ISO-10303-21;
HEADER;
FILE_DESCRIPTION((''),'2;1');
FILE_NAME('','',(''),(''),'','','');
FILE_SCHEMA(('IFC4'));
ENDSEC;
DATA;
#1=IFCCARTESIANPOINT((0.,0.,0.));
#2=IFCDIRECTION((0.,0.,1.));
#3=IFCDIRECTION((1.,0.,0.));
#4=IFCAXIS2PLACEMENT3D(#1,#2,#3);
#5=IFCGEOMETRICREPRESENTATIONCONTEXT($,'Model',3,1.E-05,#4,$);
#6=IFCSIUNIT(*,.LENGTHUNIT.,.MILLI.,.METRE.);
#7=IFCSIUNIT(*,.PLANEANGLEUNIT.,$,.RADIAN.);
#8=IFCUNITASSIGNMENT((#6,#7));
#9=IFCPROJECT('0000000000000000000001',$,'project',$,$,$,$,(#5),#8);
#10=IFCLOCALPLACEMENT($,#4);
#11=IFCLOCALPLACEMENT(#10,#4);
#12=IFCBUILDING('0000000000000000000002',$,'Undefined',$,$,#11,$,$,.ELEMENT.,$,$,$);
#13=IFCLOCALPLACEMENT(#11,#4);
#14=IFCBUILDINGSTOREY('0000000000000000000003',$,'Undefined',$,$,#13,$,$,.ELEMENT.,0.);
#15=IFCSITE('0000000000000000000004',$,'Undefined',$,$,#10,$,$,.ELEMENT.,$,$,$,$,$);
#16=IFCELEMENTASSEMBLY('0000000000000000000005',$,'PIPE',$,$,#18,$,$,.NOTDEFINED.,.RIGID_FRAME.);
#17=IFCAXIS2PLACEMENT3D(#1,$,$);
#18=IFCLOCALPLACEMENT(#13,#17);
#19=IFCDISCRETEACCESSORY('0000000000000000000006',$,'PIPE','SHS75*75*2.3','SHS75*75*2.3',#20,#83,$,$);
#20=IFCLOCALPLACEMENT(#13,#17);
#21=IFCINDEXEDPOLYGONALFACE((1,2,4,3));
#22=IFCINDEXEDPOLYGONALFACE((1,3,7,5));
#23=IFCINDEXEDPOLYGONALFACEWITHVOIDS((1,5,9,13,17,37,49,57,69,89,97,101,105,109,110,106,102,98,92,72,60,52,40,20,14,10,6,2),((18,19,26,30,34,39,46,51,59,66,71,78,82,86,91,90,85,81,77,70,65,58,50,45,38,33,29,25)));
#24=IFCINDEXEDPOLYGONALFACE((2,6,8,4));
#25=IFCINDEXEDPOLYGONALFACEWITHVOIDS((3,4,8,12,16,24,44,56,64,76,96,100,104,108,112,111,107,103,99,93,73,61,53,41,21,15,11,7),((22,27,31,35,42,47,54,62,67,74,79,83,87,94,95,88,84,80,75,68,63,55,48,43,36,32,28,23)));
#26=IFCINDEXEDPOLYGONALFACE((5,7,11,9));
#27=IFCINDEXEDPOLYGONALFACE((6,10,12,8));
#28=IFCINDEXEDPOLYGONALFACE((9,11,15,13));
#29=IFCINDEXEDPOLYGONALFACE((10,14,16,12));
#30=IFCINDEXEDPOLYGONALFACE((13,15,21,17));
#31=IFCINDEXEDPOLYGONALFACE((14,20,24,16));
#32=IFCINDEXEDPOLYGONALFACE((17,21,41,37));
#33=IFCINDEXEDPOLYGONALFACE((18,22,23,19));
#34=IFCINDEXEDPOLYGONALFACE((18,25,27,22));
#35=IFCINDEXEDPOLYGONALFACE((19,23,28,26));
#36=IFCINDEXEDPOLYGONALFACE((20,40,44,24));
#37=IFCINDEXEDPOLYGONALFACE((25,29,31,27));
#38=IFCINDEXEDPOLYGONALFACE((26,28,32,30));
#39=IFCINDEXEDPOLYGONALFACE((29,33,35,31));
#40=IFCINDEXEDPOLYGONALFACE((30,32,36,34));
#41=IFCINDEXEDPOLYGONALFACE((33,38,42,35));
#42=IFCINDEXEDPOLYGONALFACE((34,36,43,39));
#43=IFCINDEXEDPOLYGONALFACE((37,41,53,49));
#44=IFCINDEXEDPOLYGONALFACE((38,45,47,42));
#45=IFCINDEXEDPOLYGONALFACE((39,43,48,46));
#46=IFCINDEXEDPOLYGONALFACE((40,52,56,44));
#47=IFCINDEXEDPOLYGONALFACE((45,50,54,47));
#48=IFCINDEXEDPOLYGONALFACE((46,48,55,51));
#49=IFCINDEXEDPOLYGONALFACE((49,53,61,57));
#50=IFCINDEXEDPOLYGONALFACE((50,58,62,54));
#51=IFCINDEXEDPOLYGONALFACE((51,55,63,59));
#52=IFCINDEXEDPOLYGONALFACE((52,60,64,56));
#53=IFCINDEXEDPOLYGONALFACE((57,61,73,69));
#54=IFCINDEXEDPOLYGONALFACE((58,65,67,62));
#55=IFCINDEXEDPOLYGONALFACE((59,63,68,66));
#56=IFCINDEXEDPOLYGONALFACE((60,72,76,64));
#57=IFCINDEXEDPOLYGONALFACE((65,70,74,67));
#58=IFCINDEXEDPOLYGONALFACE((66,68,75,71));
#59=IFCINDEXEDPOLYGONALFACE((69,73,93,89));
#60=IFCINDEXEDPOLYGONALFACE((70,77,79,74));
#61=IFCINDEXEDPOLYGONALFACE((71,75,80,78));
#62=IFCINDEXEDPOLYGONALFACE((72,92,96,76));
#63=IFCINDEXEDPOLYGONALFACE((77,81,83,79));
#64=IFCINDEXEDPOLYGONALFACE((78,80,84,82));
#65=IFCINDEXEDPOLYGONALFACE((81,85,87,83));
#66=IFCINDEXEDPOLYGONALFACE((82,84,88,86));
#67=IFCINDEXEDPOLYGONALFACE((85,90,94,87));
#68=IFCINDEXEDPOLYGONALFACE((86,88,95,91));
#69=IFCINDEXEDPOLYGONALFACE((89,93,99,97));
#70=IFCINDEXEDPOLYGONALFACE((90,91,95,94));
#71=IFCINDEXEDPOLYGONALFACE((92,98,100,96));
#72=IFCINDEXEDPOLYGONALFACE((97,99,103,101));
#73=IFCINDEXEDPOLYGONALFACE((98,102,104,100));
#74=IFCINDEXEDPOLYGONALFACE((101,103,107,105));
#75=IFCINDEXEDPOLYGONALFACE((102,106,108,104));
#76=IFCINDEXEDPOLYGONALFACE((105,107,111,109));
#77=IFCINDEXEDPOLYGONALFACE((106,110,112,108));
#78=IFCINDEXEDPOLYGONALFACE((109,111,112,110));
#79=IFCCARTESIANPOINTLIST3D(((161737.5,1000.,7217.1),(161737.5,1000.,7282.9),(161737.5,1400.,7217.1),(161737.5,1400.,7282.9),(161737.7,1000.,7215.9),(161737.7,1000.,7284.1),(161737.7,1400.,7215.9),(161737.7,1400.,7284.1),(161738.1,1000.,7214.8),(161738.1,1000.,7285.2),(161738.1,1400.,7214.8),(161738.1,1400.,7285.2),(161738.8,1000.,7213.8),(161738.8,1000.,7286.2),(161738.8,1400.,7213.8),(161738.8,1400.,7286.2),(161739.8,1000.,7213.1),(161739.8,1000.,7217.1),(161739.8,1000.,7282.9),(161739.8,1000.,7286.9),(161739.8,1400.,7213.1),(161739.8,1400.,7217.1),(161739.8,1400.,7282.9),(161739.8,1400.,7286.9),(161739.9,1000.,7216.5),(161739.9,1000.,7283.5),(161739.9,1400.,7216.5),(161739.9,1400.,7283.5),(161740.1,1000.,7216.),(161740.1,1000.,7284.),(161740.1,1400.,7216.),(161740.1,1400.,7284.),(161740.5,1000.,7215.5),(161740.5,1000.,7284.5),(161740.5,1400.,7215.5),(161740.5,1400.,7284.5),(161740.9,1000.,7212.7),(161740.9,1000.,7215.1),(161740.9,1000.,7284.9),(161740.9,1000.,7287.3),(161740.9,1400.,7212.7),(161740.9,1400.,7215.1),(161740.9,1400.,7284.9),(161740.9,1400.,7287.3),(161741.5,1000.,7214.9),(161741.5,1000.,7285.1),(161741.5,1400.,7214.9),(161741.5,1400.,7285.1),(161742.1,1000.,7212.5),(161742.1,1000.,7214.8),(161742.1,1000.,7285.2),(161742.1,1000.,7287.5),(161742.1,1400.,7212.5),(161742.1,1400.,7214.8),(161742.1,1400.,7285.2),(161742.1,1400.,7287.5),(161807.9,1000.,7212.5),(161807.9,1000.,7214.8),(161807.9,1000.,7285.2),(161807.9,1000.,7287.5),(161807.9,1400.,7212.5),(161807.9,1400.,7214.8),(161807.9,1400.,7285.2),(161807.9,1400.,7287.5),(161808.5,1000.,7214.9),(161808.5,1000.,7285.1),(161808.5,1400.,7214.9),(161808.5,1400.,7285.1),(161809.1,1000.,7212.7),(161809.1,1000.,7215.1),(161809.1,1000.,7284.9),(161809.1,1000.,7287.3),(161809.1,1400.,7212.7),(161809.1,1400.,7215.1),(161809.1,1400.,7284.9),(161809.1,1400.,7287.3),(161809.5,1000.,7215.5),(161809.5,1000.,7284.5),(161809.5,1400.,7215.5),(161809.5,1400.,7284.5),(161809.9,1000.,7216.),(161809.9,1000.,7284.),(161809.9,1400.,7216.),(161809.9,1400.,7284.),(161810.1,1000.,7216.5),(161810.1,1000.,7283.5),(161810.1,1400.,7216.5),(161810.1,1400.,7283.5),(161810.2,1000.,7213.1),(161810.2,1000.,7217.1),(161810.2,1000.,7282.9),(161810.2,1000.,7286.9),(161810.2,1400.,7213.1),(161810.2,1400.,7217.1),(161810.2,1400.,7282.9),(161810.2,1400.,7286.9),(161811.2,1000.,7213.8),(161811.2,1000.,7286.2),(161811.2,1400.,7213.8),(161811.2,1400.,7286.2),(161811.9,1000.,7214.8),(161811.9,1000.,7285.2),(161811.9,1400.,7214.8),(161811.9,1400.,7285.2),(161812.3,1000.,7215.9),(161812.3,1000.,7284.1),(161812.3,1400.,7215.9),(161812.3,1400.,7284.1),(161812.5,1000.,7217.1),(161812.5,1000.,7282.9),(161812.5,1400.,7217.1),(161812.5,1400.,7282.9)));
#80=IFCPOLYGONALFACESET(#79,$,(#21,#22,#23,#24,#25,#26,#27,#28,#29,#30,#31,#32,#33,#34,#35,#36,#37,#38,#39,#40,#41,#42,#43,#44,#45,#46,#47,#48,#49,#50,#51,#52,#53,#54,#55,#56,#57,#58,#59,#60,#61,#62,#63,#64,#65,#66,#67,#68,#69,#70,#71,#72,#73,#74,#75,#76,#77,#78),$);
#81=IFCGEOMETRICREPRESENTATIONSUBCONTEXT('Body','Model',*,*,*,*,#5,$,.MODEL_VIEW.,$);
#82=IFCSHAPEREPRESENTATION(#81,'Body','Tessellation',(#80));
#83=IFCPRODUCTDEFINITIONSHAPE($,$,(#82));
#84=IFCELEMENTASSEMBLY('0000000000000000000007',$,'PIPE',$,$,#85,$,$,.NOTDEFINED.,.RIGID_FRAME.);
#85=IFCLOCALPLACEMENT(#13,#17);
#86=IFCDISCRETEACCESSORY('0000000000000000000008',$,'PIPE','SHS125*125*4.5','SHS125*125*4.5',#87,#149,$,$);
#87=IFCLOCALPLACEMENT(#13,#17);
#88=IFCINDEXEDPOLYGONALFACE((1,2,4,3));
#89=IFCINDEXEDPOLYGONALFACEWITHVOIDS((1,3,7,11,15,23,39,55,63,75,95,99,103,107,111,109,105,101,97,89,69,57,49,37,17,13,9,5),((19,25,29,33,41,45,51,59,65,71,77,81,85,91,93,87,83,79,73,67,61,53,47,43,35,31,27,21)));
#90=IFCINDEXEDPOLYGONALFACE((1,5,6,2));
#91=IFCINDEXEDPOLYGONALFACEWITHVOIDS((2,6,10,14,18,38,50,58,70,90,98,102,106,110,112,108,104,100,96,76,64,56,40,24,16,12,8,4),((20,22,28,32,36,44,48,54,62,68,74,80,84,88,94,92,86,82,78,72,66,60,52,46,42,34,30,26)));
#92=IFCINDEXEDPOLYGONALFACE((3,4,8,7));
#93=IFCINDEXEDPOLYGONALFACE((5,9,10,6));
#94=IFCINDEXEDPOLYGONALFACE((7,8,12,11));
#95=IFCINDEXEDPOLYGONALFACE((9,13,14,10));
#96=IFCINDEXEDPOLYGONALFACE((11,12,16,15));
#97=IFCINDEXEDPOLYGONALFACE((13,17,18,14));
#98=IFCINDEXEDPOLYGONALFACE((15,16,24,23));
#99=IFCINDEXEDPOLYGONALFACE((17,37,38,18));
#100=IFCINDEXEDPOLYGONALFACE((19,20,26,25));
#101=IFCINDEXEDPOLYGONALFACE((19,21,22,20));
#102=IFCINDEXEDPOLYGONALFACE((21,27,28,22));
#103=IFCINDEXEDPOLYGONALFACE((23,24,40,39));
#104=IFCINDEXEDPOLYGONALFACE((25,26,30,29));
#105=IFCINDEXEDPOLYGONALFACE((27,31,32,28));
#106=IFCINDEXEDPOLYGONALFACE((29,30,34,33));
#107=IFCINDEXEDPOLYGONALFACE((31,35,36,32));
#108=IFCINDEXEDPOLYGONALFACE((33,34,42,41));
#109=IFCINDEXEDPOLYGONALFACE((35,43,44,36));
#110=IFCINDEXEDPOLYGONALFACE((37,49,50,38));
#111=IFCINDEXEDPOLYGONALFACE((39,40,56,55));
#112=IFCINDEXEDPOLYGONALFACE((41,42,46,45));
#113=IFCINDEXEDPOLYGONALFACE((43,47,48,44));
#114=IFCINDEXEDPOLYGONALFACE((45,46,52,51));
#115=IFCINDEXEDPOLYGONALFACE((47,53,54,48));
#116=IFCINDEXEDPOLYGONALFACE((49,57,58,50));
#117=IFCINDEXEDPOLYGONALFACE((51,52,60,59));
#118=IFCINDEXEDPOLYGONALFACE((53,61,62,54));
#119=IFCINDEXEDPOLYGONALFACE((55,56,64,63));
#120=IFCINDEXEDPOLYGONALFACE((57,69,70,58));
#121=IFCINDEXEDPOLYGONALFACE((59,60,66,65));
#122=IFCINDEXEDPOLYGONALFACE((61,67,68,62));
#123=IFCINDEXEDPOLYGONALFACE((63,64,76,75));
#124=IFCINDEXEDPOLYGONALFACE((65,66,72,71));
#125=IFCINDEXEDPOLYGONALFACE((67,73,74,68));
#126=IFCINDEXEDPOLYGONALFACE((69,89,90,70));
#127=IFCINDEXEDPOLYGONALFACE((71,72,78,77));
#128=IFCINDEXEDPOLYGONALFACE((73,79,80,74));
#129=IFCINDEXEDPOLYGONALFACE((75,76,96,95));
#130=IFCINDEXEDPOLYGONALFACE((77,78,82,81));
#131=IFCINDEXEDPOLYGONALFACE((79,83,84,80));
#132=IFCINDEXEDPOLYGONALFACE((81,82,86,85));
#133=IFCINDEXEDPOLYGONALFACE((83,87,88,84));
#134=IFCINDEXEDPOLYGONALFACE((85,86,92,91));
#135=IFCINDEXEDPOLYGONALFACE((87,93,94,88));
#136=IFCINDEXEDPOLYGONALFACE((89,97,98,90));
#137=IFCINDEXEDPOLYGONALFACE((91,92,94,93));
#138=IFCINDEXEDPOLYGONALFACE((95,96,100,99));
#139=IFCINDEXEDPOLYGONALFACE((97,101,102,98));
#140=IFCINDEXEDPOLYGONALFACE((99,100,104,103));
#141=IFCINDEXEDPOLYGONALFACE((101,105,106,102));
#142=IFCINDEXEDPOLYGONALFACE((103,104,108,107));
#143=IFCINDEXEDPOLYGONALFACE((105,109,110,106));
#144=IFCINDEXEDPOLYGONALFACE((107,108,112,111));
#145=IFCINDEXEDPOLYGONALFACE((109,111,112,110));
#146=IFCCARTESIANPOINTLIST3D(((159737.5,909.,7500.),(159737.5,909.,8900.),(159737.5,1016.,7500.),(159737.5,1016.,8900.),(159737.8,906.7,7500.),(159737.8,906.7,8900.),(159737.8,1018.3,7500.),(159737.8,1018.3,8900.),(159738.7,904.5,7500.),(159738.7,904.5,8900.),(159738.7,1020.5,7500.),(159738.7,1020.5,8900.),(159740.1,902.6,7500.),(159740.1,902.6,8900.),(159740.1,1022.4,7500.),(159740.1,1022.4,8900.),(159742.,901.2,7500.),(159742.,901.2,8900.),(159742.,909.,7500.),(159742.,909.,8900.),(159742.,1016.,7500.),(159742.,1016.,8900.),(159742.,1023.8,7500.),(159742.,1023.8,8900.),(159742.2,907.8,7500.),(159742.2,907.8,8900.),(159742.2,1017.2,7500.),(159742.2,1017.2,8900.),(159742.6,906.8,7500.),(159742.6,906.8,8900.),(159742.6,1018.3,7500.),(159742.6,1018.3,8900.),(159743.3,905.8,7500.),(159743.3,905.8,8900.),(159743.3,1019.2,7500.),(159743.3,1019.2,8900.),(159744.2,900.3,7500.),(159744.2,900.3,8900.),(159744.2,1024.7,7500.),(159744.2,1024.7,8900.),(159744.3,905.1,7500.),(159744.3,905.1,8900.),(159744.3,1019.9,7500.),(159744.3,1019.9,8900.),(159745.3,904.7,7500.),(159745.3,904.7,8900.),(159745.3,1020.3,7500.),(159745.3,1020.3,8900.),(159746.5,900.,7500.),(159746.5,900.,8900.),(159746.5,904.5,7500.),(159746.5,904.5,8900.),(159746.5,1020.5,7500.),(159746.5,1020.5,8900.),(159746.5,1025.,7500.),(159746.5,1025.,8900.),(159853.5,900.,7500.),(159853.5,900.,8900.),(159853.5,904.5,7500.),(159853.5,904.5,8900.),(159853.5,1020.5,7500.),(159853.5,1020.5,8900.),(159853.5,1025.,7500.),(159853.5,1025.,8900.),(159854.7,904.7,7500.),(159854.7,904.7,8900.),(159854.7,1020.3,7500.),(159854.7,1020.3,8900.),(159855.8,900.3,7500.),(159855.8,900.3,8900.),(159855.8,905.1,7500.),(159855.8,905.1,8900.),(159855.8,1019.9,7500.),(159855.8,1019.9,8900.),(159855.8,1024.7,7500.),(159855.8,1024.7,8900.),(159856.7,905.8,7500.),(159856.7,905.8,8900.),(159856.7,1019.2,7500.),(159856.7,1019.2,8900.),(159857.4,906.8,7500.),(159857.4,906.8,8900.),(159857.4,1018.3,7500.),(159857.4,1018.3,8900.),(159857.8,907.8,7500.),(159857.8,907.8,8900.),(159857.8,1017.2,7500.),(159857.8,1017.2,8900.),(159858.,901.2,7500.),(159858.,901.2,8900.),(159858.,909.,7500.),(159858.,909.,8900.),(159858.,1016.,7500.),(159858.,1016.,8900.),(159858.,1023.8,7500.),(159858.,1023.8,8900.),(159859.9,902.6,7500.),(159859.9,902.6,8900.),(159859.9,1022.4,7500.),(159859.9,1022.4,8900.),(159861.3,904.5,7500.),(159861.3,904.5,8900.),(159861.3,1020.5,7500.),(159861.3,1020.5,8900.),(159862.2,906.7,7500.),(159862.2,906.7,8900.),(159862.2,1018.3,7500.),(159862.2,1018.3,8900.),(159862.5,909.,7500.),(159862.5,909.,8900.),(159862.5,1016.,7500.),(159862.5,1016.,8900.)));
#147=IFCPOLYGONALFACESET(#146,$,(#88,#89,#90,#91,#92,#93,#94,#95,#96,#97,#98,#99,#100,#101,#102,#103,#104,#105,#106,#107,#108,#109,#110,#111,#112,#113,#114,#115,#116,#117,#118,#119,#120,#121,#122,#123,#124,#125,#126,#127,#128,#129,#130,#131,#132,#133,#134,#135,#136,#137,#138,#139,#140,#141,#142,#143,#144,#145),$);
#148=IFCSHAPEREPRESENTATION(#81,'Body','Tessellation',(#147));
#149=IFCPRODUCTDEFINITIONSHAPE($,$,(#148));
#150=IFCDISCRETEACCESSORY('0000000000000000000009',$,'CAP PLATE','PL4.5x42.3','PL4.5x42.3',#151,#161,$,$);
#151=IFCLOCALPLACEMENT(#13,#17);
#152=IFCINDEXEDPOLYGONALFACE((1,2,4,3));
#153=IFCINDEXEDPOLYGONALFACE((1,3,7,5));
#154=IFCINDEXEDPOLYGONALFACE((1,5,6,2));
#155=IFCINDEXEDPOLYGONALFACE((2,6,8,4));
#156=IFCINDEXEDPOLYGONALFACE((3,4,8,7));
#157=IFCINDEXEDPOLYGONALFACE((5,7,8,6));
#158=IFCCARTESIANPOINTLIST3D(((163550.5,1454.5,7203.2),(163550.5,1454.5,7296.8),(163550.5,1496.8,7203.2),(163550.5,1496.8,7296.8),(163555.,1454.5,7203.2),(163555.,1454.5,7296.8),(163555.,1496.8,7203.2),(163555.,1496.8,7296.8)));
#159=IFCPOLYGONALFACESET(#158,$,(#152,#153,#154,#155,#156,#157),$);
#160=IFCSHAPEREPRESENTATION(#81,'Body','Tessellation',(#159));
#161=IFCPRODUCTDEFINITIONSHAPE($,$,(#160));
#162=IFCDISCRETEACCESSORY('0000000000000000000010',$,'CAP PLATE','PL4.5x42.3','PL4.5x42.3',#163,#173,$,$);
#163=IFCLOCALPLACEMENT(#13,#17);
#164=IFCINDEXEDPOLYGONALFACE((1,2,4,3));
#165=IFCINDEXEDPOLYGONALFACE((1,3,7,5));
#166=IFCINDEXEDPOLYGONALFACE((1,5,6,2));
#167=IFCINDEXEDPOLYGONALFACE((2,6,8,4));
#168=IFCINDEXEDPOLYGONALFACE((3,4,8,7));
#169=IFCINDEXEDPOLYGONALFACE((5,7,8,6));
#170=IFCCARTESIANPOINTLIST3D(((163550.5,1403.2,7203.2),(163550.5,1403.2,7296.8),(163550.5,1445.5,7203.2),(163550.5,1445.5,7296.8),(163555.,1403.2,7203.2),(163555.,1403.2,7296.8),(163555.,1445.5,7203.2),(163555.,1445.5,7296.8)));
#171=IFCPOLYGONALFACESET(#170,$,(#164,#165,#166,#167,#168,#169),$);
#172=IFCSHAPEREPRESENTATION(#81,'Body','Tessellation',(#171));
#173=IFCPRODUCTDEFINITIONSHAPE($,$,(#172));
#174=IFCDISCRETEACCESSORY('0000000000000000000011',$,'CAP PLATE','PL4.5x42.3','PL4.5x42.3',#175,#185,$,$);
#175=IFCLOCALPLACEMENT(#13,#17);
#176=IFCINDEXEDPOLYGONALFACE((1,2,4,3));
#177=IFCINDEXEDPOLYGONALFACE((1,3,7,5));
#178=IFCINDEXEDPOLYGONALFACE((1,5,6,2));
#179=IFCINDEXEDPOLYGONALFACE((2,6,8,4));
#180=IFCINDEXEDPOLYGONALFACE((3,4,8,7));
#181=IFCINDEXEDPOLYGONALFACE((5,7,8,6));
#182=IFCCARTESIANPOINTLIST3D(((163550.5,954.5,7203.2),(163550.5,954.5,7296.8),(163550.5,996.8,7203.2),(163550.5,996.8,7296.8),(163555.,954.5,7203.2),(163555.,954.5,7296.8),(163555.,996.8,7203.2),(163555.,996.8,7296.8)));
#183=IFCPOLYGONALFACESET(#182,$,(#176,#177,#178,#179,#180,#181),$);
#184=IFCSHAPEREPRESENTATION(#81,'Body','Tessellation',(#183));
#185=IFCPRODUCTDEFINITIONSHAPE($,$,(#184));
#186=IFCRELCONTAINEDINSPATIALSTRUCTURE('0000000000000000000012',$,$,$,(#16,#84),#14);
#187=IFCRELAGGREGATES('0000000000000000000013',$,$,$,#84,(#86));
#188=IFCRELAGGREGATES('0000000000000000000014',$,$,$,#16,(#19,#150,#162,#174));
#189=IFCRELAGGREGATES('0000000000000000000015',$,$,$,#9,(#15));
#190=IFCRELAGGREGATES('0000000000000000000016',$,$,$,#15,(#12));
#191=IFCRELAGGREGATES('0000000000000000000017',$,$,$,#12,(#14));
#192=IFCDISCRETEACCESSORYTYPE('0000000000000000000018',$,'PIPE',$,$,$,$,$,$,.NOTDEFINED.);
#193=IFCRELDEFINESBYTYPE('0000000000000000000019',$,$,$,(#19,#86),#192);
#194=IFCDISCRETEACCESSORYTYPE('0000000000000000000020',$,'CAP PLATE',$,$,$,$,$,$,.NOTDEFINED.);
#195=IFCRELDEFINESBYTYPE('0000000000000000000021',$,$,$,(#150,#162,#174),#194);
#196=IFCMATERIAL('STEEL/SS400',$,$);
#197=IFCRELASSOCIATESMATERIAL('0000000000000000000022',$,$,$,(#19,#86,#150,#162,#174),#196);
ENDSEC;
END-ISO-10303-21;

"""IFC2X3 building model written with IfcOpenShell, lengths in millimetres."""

from ifc_helpers import new_model, si_unit, frame, origin_with_axes, origin_2d_with_axis, place, context, subcontext, project, spatial, polyline, hollow_rectangle, outline, extrude, clip, halfspace, material, type_object, element, aggregate, save


model = new_model("IFC2X3")

# Units and contexts
model_context = context("Model", 3, precision=1e-05, world=origin_with_axes())
body_context = subcontext(model_context, "Body", "Model", "MODEL_VIEW")
ifc_project = project(units=[si_unit("LENGTHUNIT", "METRE", prefix="MILLI"), si_unit("PLANEANGLEUNIT", "RADIAN")], contexts=[model_context])

# Site, building, storey
site_placement = place(None, origin_with_axes())
site = spatial("IfcSite", under=ifc_project, at=site_placement, Name="Undefined", CompositionType="ELEMENT")
building_placement = place(site_placement, origin_with_axes())
building = spatial("IfcBuilding", under=site, at=building_placement, Name="Undefined", CompositionType="ELEMENT")
storey_placement = place(building_placement, origin_with_axes())
storey = spatial("IfcBuildingStorey", under=building, at=storey_placement, Name="Undefined", CompositionType="ELEMENT", Elevation=0.0)

# Element assembly, discrete accessory
assembly_1_placement = place(storey_placement, origin_with_axes())
assembly_1 = element("IfcElementAssembly", 1, at=assembly_1_placement, inside=storey, Name="PIPE", AssemblyPlace="NOTDEFINED", PredefinedType="RIGID_FRAME")
ifc_material_1 = material(Name="STEEL/SS400")
discrete_accessory_type_1 = type_object("IfcDiscreteAccessoryType", Name="PIPE")
discrete_accessory_1_placement = place(assembly_1_placement, frame((161775.0, 950.0, 7250.0), z_axis=(0.0, 0.0, -1.0), x_axis=(0.0, 1.0, 0.0)))
discrete_accessory_1 = element("IfcDiscreteAccessory", 2, at=discrete_accessory_1_placement, type_object=discrete_accessory_type_1, material=ifc_material_1, Name="PIPE", Description="SHS75*75*2.3", ObjectType="SHS75*75*2.3", context=body_context, shape_type="Clipping", body=[
    clip(clip(extrude(hollow_rectangle(XDim=75.0, YDim=75.0, WallThickness=2.3, InnerFilletRadius=2.3, OuterFilletRadius=4.6, at=origin_2d_with_axis()), frame((450.0, 0.0, 0.0), z_axis=(-1.0, 0.0, 0.0), x_axis=(0.0, -1.0, 0.0)), (0.0, 0.0, 1.0), 400.0), halfspace(frame((450.0, 50.7, 0.0), z_axis=(1.0, 0.0, 0.0), x_axis=(0.0, 0.0, -1.0)), False)), halfspace(frame((50.0, 61.4, 0.0), z_axis=(1.0, 0.0, 0.0), x_axis=(0.0, 0.0, -1.0)), True)),
])

# Element assembly, discrete accessory
assembly_2_placement = place(storey_placement, origin_with_axes())
assembly_2 = element("IfcElementAssembly", 3, at=assembly_2_placement, inside=storey, Name="PIPE", AssemblyPlace="NOTDEFINED", PredefinedType="RIGID_FRAME")
discrete_accessory_2_placement = place(assembly_2_placement, frame((159800.0, 962.5, 7350.0), z_axis=(0.0, 0.0, 1.0), x_axis=(1.0, 0.0, 0.0)))
discrete_accessory_2 = element("IfcDiscreteAccessory", 4, at=discrete_accessory_2_placement, type_object=discrete_accessory_type_1, material=ifc_material_1, Name="PIPE", Description="SHS125*125*4.5", ObjectType="SHS125*125*4.5", context=body_context, shape_type="Clipping", body=[
    clip(extrude(hollow_rectangle(XDim=125.0, YDim=125.0, WallThickness=4.5, InnerFilletRadius=4.5, OuterFilletRadius=9.0, at=origin_2d_with_axis()), frame((0.0, 0.0, 1550.0), z_axis=(0.0, 0.0, -1.0), x_axis=(0.0, 1.0, 0.0)), (0.0, 0.0, 1.0), 1400.0), halfspace(frame((1000.0, 0.0, 150.0), z_axis=(0.0, 0.0, 1.0), x_axis=(0.0, -1.0, 0.0)), True)),
])
aggregate(assembly_2, [discrete_accessory_2])

# Discrete accessories
discrete_accessory_type_2 = type_object("IfcDiscreteAccessoryType", Name="CAP PLATE")
discrete_accessory_3_placement = place(assembly_1_placement, frame((163552.8, 1496.8, 7203.2), z_axis=(1.0, 0.0, 0.0), x_axis=(0.0, 0.0, 1.0)))
discrete_accessory_3 = element("IfcDiscreteAccessory", 5, at=discrete_accessory_3_placement, type_object=discrete_accessory_type_2, material=ifc_material_1, Name="CAP PLATE", Description="PL4.5x42.3", ObjectType="PL4.5x42.3", context=body_context, shape_type="SweptSolid", body=[
    extrude(outline(polyline([(0.0, 0.0), (93.6, 0.0), (93.6, 42.3), (0.0, 42.3), (0.0, 0.0)])), frame((0.0, 0.0, -2.2), z_axis=(0.0, 0.0, 1.0), x_axis=(1.0, 0.0, 0.0)), (0.0, 0.0, 1.0), 4.5),
])
discrete_accessory_4_placement = place(assembly_1_placement, frame((163552.8, 1445.5, 7203.2), z_axis=(1.0, 0.0, 0.0), x_axis=(0.0, 0.0, 1.0)))
discrete_accessory_4 = element("IfcDiscreteAccessory", 6, at=discrete_accessory_4_placement, type_object=discrete_accessory_type_2, material=ifc_material_1, Name="CAP PLATE", Description="PL4.5x42.3", ObjectType="PL4.5x42.3", context=body_context, shape_type="SweptSolid", body=[
    extrude(outline(polyline([(0.0, 0.0), (93.6, 0.0), (93.6, 42.3), (0.0, 42.3), (0.0, 0.0)])), frame((0.0, 0.0, -2.2), z_axis=(0.0, 0.0, 1.0), x_axis=(1.0, 0.0, 0.0)), (0.0, 0.0, 1.0), 4.5),
])
discrete_accessory_5_placement = place(assembly_1_placement, frame((163552.8, 996.8, 7203.2), z_axis=(1.0, 0.0, 0.0), x_axis=(0.0, 0.0, 1.0)))
discrete_accessory_5 = element("IfcDiscreteAccessory", 7, at=discrete_accessory_5_placement, type_object=discrete_accessory_type_2, material=ifc_material_1, Name="CAP PLATE", Description="PL4.5x42.3", ObjectType="PL4.5x42.3", context=body_context, shape_type="SweptSolid", body=[
    extrude(outline(polyline([(0.0, 0.0), (93.6, 0.0), (93.6, 42.3), (0.0, 42.3), (0.0, 0.0)])), frame((0.0, 0.0, -2.2), z_axis=(0.0, 0.0, 1.0), x_axis=(1.0, 0.0, 0.0)), (0.0, 0.0, 1.0), 4.5),
])
aggregate(assembly_1, [discrete_accessory_1, discrete_accessory_3, discrete_accessory_4, discrete_accessory_5])

save(model, "model.ifc")
